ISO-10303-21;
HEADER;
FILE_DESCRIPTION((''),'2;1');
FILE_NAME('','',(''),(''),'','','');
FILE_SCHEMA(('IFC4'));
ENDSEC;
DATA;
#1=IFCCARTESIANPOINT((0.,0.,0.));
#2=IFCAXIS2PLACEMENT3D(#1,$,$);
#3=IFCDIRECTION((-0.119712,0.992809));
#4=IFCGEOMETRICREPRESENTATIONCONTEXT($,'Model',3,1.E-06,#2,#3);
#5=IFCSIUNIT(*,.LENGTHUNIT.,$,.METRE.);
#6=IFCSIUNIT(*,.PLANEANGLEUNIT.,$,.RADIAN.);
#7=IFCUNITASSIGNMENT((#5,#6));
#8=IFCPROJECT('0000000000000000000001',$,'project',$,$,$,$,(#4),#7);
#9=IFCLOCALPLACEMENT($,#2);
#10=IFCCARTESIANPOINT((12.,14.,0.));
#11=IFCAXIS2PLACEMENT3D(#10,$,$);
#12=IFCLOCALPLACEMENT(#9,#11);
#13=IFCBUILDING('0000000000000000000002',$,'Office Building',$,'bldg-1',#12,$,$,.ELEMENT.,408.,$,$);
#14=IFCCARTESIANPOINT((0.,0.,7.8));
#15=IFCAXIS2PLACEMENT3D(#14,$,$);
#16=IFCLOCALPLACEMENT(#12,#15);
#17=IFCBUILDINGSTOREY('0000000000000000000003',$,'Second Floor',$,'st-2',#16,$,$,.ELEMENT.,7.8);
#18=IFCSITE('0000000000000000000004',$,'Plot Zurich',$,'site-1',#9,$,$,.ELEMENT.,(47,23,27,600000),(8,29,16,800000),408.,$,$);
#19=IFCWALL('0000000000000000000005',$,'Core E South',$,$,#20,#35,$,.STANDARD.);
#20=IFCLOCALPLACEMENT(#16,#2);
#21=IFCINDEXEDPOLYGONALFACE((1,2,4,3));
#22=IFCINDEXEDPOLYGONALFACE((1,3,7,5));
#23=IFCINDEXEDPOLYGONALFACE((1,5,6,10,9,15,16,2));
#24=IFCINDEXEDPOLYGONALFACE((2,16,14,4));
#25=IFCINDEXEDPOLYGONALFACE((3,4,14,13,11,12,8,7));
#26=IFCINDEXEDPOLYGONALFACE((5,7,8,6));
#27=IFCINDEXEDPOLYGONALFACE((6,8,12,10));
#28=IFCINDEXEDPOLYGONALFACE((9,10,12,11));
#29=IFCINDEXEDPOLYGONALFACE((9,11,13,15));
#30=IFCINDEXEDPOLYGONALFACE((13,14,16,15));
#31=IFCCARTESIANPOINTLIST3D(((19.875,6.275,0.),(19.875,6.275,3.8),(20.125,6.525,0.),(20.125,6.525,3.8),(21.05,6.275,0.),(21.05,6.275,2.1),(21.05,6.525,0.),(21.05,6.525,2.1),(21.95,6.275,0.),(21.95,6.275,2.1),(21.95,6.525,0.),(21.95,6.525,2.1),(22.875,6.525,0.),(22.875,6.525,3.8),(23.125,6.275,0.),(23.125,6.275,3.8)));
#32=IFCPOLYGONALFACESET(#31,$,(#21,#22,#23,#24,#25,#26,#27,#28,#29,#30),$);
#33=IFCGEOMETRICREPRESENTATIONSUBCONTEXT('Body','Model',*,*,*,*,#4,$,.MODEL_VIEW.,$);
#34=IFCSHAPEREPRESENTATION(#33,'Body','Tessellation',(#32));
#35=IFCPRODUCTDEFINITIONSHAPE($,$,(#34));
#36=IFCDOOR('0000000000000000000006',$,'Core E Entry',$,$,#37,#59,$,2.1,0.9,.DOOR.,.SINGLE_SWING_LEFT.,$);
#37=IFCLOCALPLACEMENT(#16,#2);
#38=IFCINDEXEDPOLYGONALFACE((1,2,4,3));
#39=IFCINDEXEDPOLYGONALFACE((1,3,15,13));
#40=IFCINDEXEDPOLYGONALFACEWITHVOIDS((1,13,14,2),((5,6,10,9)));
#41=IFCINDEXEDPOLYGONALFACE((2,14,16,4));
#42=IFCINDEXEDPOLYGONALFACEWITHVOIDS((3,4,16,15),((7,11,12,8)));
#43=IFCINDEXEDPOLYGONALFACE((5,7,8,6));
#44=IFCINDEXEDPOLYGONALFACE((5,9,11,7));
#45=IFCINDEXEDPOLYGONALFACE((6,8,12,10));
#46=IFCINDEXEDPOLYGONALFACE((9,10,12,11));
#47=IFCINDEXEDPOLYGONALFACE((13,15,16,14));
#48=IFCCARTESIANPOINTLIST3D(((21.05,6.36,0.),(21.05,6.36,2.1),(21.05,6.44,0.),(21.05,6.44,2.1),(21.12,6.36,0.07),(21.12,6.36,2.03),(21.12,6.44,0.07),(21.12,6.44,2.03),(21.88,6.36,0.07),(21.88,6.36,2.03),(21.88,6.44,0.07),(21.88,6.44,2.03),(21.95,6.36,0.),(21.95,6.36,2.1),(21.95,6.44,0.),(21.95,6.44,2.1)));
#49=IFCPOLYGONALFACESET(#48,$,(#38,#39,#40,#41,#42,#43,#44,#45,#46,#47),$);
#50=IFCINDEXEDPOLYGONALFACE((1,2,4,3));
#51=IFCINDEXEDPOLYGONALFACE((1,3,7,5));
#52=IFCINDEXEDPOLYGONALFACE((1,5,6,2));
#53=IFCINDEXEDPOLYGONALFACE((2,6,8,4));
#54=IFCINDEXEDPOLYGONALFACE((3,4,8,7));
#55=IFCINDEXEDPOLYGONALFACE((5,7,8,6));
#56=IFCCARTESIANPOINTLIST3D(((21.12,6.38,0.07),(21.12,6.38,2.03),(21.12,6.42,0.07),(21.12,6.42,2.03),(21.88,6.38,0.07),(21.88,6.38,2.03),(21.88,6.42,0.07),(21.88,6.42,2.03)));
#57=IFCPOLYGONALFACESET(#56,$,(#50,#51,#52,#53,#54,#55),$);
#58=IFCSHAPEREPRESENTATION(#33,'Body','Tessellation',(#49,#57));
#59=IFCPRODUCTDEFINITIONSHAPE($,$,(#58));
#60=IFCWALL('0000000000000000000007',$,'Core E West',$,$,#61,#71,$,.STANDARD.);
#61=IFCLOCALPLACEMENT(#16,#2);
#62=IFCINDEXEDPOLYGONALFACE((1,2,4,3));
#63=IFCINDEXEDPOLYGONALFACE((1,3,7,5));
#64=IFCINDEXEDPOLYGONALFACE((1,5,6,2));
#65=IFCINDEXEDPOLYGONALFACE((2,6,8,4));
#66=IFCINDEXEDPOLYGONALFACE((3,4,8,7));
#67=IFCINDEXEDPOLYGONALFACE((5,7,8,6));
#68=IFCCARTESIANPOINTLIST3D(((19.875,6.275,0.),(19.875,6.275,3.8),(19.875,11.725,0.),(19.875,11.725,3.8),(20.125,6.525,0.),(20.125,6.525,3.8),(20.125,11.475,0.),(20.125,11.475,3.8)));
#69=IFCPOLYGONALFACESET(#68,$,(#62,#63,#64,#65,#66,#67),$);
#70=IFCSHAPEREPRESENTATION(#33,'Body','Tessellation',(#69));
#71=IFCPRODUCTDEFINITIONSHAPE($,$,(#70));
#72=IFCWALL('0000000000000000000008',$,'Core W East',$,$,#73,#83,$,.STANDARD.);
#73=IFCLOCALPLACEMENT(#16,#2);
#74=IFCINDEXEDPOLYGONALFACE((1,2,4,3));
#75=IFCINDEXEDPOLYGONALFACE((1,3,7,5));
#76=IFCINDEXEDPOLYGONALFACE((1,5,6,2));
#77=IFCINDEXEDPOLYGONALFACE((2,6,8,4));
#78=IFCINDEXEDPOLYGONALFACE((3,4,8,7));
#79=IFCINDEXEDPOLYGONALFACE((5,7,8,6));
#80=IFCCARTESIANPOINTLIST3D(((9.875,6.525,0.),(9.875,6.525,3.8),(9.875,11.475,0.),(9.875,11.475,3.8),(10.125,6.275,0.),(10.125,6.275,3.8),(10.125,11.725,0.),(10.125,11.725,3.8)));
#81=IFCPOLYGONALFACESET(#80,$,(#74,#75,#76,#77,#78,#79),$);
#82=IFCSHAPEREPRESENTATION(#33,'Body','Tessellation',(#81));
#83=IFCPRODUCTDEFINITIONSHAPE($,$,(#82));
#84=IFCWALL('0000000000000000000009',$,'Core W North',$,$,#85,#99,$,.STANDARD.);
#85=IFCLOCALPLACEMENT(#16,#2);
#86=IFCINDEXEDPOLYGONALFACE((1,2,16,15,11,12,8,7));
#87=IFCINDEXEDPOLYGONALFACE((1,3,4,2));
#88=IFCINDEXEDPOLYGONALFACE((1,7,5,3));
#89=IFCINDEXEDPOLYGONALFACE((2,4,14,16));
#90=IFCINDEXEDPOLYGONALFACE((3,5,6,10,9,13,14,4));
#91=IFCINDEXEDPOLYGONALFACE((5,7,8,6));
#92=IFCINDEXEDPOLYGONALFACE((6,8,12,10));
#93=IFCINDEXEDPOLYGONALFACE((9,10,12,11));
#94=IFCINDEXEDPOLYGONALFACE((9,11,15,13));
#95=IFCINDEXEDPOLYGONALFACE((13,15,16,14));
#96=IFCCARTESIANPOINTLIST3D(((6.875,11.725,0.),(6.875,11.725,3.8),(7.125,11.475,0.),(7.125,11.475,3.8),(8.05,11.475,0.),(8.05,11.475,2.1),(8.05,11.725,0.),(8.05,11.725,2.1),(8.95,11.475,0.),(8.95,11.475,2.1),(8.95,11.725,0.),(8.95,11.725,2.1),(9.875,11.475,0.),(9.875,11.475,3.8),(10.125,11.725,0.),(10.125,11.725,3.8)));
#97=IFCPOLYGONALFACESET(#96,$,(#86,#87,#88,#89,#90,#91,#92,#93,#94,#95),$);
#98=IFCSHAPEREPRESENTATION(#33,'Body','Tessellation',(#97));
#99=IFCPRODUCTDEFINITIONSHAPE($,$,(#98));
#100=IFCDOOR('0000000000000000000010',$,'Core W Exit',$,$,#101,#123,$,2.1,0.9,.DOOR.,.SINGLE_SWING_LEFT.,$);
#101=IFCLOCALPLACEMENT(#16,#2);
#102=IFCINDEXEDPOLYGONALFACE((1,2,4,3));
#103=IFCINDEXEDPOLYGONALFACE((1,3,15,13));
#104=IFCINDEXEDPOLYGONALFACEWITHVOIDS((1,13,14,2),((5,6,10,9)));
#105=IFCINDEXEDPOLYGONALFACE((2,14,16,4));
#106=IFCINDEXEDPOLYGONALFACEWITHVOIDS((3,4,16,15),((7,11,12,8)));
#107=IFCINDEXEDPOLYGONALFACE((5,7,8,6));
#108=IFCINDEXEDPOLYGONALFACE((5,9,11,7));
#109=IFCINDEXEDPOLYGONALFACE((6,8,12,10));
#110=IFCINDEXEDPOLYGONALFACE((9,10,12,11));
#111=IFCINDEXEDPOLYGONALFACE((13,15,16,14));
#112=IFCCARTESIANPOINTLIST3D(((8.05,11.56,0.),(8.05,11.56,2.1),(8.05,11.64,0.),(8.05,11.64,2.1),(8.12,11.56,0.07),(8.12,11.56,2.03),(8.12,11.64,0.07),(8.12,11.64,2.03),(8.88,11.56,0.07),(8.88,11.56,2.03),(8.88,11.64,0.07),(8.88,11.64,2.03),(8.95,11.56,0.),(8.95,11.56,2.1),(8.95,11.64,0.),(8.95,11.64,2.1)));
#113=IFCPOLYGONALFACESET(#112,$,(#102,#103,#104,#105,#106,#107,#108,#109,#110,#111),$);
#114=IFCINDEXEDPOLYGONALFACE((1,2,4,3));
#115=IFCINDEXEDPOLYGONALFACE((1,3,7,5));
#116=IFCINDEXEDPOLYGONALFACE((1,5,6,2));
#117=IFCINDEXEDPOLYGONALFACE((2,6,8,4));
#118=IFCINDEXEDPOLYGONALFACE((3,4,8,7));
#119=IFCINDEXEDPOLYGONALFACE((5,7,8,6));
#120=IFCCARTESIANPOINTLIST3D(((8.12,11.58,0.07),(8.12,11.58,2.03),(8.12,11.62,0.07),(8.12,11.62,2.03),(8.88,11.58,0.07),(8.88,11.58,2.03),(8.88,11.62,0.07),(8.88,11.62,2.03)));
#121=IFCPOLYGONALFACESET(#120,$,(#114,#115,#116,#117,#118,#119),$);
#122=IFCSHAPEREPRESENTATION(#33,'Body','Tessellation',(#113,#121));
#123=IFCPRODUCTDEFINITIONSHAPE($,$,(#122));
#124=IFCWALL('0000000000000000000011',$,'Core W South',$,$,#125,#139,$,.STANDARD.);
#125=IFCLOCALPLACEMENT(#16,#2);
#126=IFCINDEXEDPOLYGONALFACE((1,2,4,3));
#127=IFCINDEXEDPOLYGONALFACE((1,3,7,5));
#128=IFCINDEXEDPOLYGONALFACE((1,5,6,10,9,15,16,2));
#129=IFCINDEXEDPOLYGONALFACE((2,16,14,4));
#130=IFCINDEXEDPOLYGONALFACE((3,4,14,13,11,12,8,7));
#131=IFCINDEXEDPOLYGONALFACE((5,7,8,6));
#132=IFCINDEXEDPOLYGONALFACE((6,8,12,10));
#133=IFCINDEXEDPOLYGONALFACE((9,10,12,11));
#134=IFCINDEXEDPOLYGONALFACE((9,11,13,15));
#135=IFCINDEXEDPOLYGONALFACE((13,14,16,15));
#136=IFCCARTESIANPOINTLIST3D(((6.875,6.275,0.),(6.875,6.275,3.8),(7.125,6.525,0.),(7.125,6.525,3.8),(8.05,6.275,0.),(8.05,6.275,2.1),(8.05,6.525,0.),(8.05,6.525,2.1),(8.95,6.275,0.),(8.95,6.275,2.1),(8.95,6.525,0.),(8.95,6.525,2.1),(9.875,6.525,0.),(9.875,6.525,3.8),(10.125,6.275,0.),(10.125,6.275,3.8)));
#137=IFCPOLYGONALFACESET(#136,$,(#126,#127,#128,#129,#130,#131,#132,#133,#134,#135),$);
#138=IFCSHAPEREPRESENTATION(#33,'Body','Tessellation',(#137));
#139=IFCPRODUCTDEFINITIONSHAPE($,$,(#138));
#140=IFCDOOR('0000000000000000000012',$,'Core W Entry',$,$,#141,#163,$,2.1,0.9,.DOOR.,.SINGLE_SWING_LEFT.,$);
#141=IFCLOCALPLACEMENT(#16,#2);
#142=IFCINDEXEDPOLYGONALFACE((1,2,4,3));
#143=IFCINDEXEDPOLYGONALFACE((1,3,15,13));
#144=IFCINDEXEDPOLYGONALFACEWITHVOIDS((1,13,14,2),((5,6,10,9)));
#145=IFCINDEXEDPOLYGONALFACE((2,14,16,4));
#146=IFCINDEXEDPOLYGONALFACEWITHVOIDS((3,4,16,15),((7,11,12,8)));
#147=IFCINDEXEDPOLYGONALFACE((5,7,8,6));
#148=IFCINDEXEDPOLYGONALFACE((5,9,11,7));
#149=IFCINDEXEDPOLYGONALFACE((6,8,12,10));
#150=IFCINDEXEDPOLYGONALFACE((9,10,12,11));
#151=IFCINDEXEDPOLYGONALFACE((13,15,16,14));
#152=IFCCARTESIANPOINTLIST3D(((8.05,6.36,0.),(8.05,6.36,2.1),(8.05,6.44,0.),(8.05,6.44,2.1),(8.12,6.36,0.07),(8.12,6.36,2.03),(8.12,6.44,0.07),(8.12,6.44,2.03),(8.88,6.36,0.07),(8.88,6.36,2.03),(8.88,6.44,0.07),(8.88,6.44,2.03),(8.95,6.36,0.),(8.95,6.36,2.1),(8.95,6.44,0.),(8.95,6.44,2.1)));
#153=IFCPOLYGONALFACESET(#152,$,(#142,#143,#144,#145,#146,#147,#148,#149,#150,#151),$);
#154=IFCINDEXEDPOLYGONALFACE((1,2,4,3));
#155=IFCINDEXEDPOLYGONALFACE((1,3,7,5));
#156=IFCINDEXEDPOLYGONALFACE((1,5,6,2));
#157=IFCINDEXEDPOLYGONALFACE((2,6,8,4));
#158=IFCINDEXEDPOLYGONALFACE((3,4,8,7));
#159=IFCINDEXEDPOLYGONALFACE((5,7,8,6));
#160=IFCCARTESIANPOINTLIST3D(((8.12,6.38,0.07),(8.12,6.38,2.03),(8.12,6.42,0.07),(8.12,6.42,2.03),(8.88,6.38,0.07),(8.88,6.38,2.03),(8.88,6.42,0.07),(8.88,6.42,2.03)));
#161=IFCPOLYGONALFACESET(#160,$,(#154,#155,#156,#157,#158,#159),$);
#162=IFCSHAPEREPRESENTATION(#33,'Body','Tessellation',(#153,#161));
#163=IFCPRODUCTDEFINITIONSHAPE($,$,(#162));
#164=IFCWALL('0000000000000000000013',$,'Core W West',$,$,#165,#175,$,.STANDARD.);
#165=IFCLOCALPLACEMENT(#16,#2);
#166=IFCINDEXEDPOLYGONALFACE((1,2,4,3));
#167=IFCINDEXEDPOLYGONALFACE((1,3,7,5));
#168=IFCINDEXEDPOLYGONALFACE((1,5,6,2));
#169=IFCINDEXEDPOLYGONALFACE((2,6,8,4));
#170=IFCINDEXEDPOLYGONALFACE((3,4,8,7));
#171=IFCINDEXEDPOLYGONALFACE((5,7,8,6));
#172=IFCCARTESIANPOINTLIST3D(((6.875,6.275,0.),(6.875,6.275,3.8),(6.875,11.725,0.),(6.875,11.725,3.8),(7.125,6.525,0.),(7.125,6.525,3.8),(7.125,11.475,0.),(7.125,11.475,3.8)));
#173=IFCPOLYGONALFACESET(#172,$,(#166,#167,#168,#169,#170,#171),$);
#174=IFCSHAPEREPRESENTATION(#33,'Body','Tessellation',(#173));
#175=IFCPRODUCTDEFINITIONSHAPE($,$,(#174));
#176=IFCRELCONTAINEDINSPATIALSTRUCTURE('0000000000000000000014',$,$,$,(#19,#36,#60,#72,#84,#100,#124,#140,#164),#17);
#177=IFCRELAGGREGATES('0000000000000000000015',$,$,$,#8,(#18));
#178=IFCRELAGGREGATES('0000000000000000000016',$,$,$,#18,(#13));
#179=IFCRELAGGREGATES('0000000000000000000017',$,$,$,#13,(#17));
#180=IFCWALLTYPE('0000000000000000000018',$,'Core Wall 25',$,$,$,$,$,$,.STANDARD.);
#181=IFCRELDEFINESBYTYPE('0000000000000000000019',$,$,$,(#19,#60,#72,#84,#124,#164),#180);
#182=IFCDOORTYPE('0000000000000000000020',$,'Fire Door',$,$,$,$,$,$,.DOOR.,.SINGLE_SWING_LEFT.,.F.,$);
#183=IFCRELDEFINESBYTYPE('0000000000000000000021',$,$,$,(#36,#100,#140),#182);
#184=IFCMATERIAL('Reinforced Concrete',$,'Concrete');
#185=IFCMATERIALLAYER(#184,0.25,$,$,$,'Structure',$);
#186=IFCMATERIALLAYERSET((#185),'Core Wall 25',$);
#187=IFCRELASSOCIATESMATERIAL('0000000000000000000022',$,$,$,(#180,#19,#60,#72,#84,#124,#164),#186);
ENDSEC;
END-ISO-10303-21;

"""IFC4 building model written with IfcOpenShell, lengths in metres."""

from ifc_helpers import new_model, si_unit, direction, frame, frame_2d, origin, origin_2d, place, context, subcontext, project, spatial, polyline, rectangle, outline, extrude, material, layer, layer_set, layer_usage, type_object, element, fill, save


model = new_model("IFC4")

# Units and contexts
model_context = context("Model", 3, precision=1e-06, world=origin(), true_north=direction((-0.119712, 0.992809)))
body_context = subcontext(model_context, "Body", "Model", "MODEL_VIEW")
ifc_project = project(units=[si_unit("LENGTHUNIT", "METRE"), si_unit("PLANEANGLEUNIT", "RADIAN")], contexts=[model_context])

# Site, building, storey
site_placement = place(None, origin())
site = spatial("IfcSite", under=ifc_project, at=site_placement, Name="Plot Zurich", ObjectType="site-1", CompositionType="ELEMENT", RefLatitude=(47, 23, 27, 600000), RefLongitude=(8, 29, 16, 800000), RefElevation=408.0)
building_placement = place(site_placement, frame((12.0, 14.0, 0.0)))
building = spatial("IfcBuilding", under=site, at=building_placement, Name="Office Building", ObjectType="bldg-1", CompositionType="ELEMENT", ElevationOfRefHeight=408.0)
storey_placement = place(building_placement, frame((0.0, 0.0, 7.8)))
storey = spatial("IfcBuildingStorey", under=building, at=storey_placement, Name="Second Floor", ObjectType="st-2", CompositionType="ELEMENT", Elevation=7.8)

# Shared definitions
ifc_material_1 = material(Name="Reinforced Concrete", Category="Concrete")

# Shared definitions
ifc_layer_1 = layer(ifc_material_1, 0.25, Category="Structure")
ifc_layer_set_1 = layer_set([ifc_layer_1], Name="Core Wall 25")
wall_type_1 = type_object("IfcWallType", Name="Core Wall 25", PredefinedType="STANDARD", material=ifc_layer_set_1)

# Wall, opening, door
door_type = type_object("IfcDoorType", Name="Fire Door", OperationType="SINGLE_SWING_LEFT", ParameterTakesPrecedence=False, PredefinedType="DOOR")
ifc_layer_usage_1 = layer_usage(ifc_layer_set_1, "AXIS2", "NEGATIVE", 0.125)
wall_1_placement = place(storey_placement, origin())
wall_1 = element("IfcWall", 1, at=wall_1_placement, inside=storey, type_object=wall_type_1, material=ifc_layer_usage_1, Name="Core E South", PredefinedType="STANDARD", context=body_context, shape_type="SweptSolid", body=[
    extrude(outline(polyline([(19.875, 6.275), (23.125, 6.275), (22.875, 6.525), (20.125, 6.525), (19.875, 6.275)])), origin(), (0.0, 0.0, 1.0), 3.8),
])
opening_1_placement = place(wall_1_placement, frame((21.5, 6.4, 0.0), z_axis=(0.0, 0.0, 1.0), x_axis=(1.0, 0.0, 0.0)))
opening_1 = element("IfcOpeningElement", 2, at=opening_1_placement, cuts=wall_1, PredefinedType="OPENING", context=body_context, shape_type="SweptSolid", body=[
    extrude(rectangle(XDim=0.9, YDim=0.25, at=origin_2d()), origin(), (0.0, 0.0, 1.0), 2.1),
])
door_1_placement = place(opening_1_placement, frame((0.0, 0.0, 0.0), z_axis=(0.0, -1.0, 0.0), x_axis=(1.0, 0.0, 0.0)))
door_1 = element("IfcDoor", 3, at=door_1_placement, inside=storey, type_object=door_type, Name="Core E Entry", OperationType="SINGLE_SWING_LEFT", OverallHeight=2.1, OverallWidth=0.9, PredefinedType="DOOR", context=body_context, shape_type="SweptSolid", body=[
    extrude(outline(polyline([(-0.45, 0.0), (0.45, 0.0), (0.45, 2.1), (-0.45, 2.1), (-0.45, 0.0)]), holes=[polyline([(-0.38, 0.07), (0.38, 0.07), (0.38, 2.03), (-0.38, 2.03), (-0.38, 0.07)])]), frame((0.0, 0.0, -0.04)), (0.0, 0.0, 1.0), 0.08),
    extrude(rectangle(XDim=0.76, YDim=1.96, at=frame_2d((0.0, 1.05))), frame((0.0, 0.0, -0.02)), (0.0, 0.0, 1.0), 0.04),
])
fill(opening_1, door_1)

# Walls
ifc_layer_usage_2 = layer_usage(ifc_layer_set_1, "AXIS2", "NEGATIVE", 0.125)
wall_2_placement = place(storey_placement, origin())
element("IfcWall", 4, at=wall_2_placement, inside=storey, type_object=wall_type_1, material=ifc_layer_usage_2, Name="Core E West", PredefinedType="STANDARD", context=body_context, shape_type="SweptSolid", body=[
    extrude(outline(polyline([(19.875, 11.725), (19.875, 6.275), (20.125, 6.525), (20.125, 11.475), (19.875, 11.725)])), origin(), (0.0, 0.0, 1.0), 3.8),
])
ifc_layer_usage_3 = layer_usage(ifc_layer_set_1, "AXIS2", "NEGATIVE", 0.125)
wall_3_placement = place(storey_placement, origin())
element("IfcWall", 5, at=wall_3_placement, inside=storey, type_object=wall_type_1, material=ifc_layer_usage_3, Name="Core W East", PredefinedType="STANDARD", context=body_context, shape_type="SweptSolid", body=[
    extrude(outline(polyline([(10.125, 6.275), (10.125, 11.725), (9.875, 11.475), (9.875, 6.525), (10.125, 6.275)])), origin(), (0.0, 0.0, 1.0), 3.8),
])

# Walls, openings, doors
ifc_layer_usage_4 = layer_usage(ifc_layer_set_1, "AXIS2", "NEGATIVE", 0.125)
wall_4_placement = place(storey_placement, origin())
wall_4 = element("IfcWall", 6, at=wall_4_placement, inside=storey, type_object=wall_type_1, material=ifc_layer_usage_4, Name="Core W North", PredefinedType="STANDARD", context=body_context, shape_type="SweptSolid", body=[
    extrude(outline(polyline([(10.125, 11.725), (6.875, 11.725), (7.125, 11.475), (9.875, 11.475), (10.125, 11.725)])), origin(), (0.0, 0.0, 1.0), 3.8),
])
opening_2_placement = place(wall_4_placement, frame((8.5, 11.6, 0.0), z_axis=(0.0, 0.0, 1.0), x_axis=(-1.0, 0.0, 0.0)))
opening_2 = element("IfcOpeningElement", 7, at=opening_2_placement, cuts=wall_4, PredefinedType="OPENING", context=body_context, shape_type="SweptSolid", body=[
    extrude(rectangle(XDim=0.9, YDim=0.25, at=origin_2d()), origin(), (0.0, 0.0, 1.0), 2.1),
])
door_2_placement = place(opening_2_placement, frame((0.0, 0.0, 0.0), z_axis=(0.0, -1.0, 0.0), x_axis=(1.0, 0.0, 0.0)))
door_2 = element("IfcDoor", 8, at=door_2_placement, inside=storey, type_object=door_type, Name="Core W Exit", OperationType="SINGLE_SWING_LEFT", OverallHeight=2.1, OverallWidth=0.9, PredefinedType="DOOR", context=body_context, shape_type="SweptSolid", body=[
    extrude(outline(polyline([(-0.45, 0.0), (0.45, 0.0), (0.45, 2.1), (-0.45, 2.1), (-0.45, 0.0)]), holes=[polyline([(-0.38, 0.07), (0.38, 0.07), (0.38, 2.03), (-0.38, 2.03), (-0.38, 0.07)])]), frame((0.0, 0.0, -0.04)), (0.0, 0.0, 1.0), 0.08),
    extrude(rectangle(XDim=0.76, YDim=1.96, at=frame_2d((0.0, 1.05))), frame((0.0, 0.0, -0.02)), (0.0, 0.0, 1.0), 0.04),
])
fill(opening_2, door_2)
ifc_layer_usage_5 = layer_usage(ifc_layer_set_1, "AXIS2", "NEGATIVE", 0.125)
wall_5_placement = place(storey_placement, origin())
wall_5 = element("IfcWall", 9, at=wall_5_placement, inside=storey, type_object=wall_type_1, material=ifc_layer_usage_5, Name="Core W South", PredefinedType="STANDARD", context=body_context, shape_type="SweptSolid", body=[
    extrude(outline(polyline([(6.875, 6.275), (10.125, 6.275), (9.875, 6.525), (7.125, 6.525), (6.875, 6.275)])), origin(), (0.0, 0.0, 1.0), 3.8),
])
opening_3_placement = place(wall_5_placement, frame((8.5, 6.4, 0.0), z_axis=(0.0, 0.0, 1.0), x_axis=(1.0, 0.0, 0.0)))
opening_3 = element("IfcOpeningElement", 10, at=opening_3_placement, cuts=wall_5, PredefinedType="OPENING", context=body_context, shape_type="SweptSolid", body=[
    extrude(rectangle(XDim=0.9, YDim=0.25, at=origin_2d()), origin(), (0.0, 0.0, 1.0), 2.1),
])
door_3_placement = place(opening_3_placement, frame((0.0, 0.0, 0.0), z_axis=(0.0, -1.0, 0.0), x_axis=(1.0, 0.0, 0.0)))
door_3 = element("IfcDoor", 11, at=door_3_placement, inside=storey, type_object=door_type, Name="Core W Entry", OperationType="SINGLE_SWING_LEFT", OverallHeight=2.1, OverallWidth=0.9, PredefinedType="DOOR", context=body_context, shape_type="SweptSolid", body=[
    extrude(outline(polyline([(-0.45, 0.0), (0.45, 0.0), (0.45, 2.1), (-0.45, 2.1), (-0.45, 0.0)]), holes=[polyline([(-0.38, 0.07), (0.38, 0.07), (0.38, 2.03), (-0.38, 2.03), (-0.38, 0.07)])]), frame((0.0, 0.0, -0.04)), (0.0, 0.0, 1.0), 0.08),
    extrude(rectangle(XDim=0.76, YDim=1.96, at=frame_2d((0.0, 1.05))), frame((0.0, 0.0, -0.02)), (0.0, 0.0, 1.0), 0.04),
])
fill(opening_3, door_3)

# Wall
ifc_layer_usage_6 = layer_usage(ifc_layer_set_1, "AXIS2", "NEGATIVE", 0.125)
wall_6_placement = place(storey_placement, origin())
element("IfcWall", 12, at=wall_6_placement, inside=storey, type_object=wall_type_1, material=ifc_layer_usage_6, Name="Core W West", PredefinedType="STANDARD", context=body_context, shape_type="SweptSolid", body=[
    extrude(outline(polyline([(6.875, 11.725), (6.875, 6.275), (7.125, 6.525), (7.125, 11.475), (6.875, 11.725)])), origin(), (0.0, 0.0, 1.0), 3.8),
])

save(model, "model.ifc")
